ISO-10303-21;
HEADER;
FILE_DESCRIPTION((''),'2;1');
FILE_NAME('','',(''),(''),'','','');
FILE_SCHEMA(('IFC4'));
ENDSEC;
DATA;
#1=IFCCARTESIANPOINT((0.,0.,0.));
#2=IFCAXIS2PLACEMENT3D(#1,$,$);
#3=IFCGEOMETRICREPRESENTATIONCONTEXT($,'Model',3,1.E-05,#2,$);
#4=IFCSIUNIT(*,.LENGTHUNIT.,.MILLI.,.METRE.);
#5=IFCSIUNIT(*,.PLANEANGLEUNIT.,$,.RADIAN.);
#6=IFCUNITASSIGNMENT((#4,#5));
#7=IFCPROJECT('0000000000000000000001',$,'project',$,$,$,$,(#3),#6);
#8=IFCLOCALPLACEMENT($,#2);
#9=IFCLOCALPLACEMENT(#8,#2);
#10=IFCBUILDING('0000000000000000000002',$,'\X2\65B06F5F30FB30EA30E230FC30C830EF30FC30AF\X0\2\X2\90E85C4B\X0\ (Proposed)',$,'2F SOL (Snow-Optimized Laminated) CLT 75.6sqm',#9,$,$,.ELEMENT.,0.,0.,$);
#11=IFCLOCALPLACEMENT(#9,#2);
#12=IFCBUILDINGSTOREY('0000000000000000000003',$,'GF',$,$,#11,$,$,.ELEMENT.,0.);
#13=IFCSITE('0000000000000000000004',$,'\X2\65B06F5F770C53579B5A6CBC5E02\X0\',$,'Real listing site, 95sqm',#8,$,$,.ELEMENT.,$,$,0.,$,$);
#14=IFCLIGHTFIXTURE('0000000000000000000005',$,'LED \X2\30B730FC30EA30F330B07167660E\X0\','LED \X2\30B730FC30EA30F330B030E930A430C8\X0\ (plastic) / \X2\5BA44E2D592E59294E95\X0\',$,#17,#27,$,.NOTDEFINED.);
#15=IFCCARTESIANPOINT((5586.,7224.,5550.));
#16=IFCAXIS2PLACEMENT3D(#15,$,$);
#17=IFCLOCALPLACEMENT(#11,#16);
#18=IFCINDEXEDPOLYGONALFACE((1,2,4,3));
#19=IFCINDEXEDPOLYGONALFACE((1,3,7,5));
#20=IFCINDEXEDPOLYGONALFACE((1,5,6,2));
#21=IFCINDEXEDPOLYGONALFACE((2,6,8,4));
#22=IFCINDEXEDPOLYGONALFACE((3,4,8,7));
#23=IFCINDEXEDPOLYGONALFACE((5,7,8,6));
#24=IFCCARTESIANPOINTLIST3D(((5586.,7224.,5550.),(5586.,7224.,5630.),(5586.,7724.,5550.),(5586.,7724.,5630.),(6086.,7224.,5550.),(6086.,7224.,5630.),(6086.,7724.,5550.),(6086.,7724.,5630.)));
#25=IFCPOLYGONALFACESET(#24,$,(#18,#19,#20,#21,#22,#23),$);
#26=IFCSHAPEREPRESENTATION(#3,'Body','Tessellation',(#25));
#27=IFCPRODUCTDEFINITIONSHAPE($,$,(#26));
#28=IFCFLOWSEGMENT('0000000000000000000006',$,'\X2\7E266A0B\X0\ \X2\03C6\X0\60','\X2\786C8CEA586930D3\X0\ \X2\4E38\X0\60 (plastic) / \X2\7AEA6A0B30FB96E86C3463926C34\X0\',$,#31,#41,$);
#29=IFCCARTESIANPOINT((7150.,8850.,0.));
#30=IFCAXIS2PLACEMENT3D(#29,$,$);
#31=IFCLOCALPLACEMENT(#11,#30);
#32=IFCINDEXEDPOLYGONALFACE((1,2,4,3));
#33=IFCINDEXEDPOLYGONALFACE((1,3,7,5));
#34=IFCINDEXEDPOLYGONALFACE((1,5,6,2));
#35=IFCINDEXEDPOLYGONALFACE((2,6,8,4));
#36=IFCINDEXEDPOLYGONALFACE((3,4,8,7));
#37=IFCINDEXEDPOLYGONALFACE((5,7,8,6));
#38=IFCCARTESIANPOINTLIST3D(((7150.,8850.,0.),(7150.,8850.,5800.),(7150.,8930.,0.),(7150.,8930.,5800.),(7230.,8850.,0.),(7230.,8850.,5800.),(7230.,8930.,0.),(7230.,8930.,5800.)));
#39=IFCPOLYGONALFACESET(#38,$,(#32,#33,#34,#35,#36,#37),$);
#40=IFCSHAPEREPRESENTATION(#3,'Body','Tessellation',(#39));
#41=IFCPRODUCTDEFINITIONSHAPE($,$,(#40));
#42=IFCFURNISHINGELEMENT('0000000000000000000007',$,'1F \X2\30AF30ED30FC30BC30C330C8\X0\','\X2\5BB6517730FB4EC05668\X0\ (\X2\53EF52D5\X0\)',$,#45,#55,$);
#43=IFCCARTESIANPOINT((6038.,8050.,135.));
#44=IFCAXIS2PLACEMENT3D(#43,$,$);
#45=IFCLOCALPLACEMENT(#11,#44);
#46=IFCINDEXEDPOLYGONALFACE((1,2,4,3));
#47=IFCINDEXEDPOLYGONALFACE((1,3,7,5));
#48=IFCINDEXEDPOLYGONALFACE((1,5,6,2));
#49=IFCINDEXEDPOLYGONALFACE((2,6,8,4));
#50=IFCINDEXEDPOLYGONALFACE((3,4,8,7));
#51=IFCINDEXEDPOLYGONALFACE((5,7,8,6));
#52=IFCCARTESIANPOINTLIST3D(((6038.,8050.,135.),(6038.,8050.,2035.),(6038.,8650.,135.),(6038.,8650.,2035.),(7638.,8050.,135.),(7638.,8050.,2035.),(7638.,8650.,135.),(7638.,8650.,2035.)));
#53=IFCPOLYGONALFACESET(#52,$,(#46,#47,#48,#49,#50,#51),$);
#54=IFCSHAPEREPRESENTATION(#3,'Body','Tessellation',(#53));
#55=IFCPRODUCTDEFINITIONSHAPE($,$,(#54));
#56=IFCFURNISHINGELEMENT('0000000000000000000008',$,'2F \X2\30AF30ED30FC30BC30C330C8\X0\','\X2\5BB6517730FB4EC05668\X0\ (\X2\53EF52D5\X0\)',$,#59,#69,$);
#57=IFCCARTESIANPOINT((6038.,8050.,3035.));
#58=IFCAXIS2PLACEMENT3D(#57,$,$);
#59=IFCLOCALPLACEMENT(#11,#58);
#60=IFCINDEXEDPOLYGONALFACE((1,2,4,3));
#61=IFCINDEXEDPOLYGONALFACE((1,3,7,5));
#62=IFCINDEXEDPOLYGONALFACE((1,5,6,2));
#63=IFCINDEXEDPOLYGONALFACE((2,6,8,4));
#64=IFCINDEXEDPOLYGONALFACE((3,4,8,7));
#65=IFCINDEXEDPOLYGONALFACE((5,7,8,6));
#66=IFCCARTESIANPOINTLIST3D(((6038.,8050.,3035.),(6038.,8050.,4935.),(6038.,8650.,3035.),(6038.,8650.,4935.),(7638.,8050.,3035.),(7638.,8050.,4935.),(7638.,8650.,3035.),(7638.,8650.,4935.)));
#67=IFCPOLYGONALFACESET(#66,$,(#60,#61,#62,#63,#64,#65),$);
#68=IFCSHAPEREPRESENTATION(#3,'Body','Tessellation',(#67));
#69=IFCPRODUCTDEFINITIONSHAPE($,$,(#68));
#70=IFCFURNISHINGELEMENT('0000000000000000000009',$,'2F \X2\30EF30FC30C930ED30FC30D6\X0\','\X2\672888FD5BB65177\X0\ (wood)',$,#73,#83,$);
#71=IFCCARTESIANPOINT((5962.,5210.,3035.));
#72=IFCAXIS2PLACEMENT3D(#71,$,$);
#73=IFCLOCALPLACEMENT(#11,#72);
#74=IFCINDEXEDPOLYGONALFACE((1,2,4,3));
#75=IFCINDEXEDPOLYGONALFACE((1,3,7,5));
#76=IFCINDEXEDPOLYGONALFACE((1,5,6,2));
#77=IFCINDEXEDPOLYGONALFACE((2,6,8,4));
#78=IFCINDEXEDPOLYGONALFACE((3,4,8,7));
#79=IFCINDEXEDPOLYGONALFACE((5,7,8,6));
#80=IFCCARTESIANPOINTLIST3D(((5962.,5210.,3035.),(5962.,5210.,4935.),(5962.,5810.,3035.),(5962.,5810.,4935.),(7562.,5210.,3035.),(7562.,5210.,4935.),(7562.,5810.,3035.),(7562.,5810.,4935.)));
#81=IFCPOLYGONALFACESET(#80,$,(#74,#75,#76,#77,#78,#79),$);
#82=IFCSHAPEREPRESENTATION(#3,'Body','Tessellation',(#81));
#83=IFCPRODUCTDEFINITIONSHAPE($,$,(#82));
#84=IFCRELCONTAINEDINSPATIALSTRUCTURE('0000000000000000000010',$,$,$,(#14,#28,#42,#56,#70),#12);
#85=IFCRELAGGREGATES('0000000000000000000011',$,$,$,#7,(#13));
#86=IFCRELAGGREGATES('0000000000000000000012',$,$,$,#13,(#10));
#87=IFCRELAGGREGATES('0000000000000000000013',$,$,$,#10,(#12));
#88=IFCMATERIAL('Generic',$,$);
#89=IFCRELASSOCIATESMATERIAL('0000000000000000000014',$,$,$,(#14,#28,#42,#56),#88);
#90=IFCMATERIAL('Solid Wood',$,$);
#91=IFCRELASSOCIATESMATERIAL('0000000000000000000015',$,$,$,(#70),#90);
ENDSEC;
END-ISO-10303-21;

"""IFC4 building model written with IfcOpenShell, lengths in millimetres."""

from ifc_helpers import new_model, si_unit, frame, frame_2d, origin, place, context, project, spatial, rectangle, extrude, material, element, save


model = new_model("IFC4")

# Units and contexts
model_context = context("Model", 3, precision=1e-05, world=origin())
ifc_project = project(units=[si_unit("LENGTHUNIT", "METRE", prefix="MILLI"), si_unit("PLANEANGLEUNIT", "RADIAN")], contexts=[model_context])

# Site, building, storey
site_placement = place(None, origin())
site = spatial("IfcSite", under=ifc_project, at=site_placement, Name="新潟県南魚沼市", ObjectType="Real listing site, 95sqm", CompositionType="ELEMENT", RefElevation=0.0)
building_placement = place(site_placement, origin())
building = spatial("IfcBuilding", under=site, at=building_placement, Name="新潟・リモートワーク2部屋 (Proposed)", ObjectType="2F SOL (Snow-Optimized Laminated) CLT 75.6sqm", CompositionType="ELEMENT", ElevationOfRefHeight=0.0, ElevationOfTerrain=0.0)
storey_placement = place(building_placement, origin())
storey = spatial("IfcBuildingStorey", under=building, at=storey_placement, Name="GF", CompositionType="ELEMENT", Elevation=0.0)

# Shared definitions
ifc_material_1 = material(Name="Solid Wood")

# Shared definitions
ifc_material_2 = material(Name="Generic")

# Light fixture
light_fixture_1_placement = place(storey_placement, frame((5586.0, 7224.0, 5550.0)))
element("IfcLightFixture", 1, at=light_fixture_1_placement, inside=storey, material=ifc_material_2, Name="LED シーリング照明", Description="LED シーリングライト (plastic) / 室中央天井", PredefinedType="NOTDEFINED", context=model_context, shape_type="SweptSolid", body=[
    extrude(rectangle(XDim=500.0, YDim=500.0, at=frame_2d((250.0, 250.0))), frame((5586.0, 7224.0, 5550.0)), (0.0, 0.0, 1.0), 80.0),
])

# Flow segment
flow_segment_placement = place(storey_placement, frame((7150.0, 8850.0, 0.0)))
element("IfcFlowSegment", 2, at=flow_segment_placement, inside=storey, material=ifc_material_2, Name="縦樋 φ60", Description="硬質塩ビ 丸60 (plastic) / 竪樋・雨水排水", context=model_context, shape_type="SweptSolid", body=[
    extrude(rectangle(XDim=80.0, YDim=80.0, at=frame_2d((40.0, 40.0))), frame((7150.0, 8850.0, 0.0)), (0.0, 0.0, 1.0), 5800.0),
])

# Furnishing elements
furnishing_1_placement = place(storey_placement, frame((6038.0, 8050.0, 135.0)))
element("IfcFurnishingElement", 3, at=furnishing_1_placement, inside=storey, material=ifc_material_2, Name="1F クローゼット", Description="家具・什器 (可動)", context=model_context, shape_type="SweptSolid", body=[
    extrude(rectangle(XDim=1600.0, YDim=600.0, at=frame_2d((800.0, 300.0))), frame((6038.0, 8050.0, 135.0)), (0.0, 0.0, 1.0), 1900.0),
])
furnishing_2_placement = place(storey_placement, frame((6038.0, 8050.0, 3035.0)))
element("IfcFurnishingElement", 4, at=furnishing_2_placement, inside=storey, material=ifc_material_2, Name="2F クローゼット", Description="家具・什器 (可動)", context=model_context, shape_type="SweptSolid", body=[
    extrude(rectangle(XDim=1600.0, YDim=600.0, at=frame_2d((800.0, 300.0))), frame((6038.0, 8050.0, 3035.0)), (0.0, 0.0, 1.0), 1900.0),
])
furnishing_3_placement = place(storey_placement, frame((5962.0, 5210.0, 3035.0)))
element("IfcFurnishingElement", 5, at=furnishing_3_placement, inside=storey, material=ifc_material_1, Name="2F ワードローブ", Description="木製家具 (wood)", context=model_context, shape_type="SweptSolid", body=[
    extrude(rectangle(XDim=1600.0, YDim=600.0, at=frame_2d((800.0, 300.0))), frame((5962.0, 5210.0, 3035.0)), (0.0, 0.0, 1.0), 1900.0),
])

save(model, "model.ifc")
